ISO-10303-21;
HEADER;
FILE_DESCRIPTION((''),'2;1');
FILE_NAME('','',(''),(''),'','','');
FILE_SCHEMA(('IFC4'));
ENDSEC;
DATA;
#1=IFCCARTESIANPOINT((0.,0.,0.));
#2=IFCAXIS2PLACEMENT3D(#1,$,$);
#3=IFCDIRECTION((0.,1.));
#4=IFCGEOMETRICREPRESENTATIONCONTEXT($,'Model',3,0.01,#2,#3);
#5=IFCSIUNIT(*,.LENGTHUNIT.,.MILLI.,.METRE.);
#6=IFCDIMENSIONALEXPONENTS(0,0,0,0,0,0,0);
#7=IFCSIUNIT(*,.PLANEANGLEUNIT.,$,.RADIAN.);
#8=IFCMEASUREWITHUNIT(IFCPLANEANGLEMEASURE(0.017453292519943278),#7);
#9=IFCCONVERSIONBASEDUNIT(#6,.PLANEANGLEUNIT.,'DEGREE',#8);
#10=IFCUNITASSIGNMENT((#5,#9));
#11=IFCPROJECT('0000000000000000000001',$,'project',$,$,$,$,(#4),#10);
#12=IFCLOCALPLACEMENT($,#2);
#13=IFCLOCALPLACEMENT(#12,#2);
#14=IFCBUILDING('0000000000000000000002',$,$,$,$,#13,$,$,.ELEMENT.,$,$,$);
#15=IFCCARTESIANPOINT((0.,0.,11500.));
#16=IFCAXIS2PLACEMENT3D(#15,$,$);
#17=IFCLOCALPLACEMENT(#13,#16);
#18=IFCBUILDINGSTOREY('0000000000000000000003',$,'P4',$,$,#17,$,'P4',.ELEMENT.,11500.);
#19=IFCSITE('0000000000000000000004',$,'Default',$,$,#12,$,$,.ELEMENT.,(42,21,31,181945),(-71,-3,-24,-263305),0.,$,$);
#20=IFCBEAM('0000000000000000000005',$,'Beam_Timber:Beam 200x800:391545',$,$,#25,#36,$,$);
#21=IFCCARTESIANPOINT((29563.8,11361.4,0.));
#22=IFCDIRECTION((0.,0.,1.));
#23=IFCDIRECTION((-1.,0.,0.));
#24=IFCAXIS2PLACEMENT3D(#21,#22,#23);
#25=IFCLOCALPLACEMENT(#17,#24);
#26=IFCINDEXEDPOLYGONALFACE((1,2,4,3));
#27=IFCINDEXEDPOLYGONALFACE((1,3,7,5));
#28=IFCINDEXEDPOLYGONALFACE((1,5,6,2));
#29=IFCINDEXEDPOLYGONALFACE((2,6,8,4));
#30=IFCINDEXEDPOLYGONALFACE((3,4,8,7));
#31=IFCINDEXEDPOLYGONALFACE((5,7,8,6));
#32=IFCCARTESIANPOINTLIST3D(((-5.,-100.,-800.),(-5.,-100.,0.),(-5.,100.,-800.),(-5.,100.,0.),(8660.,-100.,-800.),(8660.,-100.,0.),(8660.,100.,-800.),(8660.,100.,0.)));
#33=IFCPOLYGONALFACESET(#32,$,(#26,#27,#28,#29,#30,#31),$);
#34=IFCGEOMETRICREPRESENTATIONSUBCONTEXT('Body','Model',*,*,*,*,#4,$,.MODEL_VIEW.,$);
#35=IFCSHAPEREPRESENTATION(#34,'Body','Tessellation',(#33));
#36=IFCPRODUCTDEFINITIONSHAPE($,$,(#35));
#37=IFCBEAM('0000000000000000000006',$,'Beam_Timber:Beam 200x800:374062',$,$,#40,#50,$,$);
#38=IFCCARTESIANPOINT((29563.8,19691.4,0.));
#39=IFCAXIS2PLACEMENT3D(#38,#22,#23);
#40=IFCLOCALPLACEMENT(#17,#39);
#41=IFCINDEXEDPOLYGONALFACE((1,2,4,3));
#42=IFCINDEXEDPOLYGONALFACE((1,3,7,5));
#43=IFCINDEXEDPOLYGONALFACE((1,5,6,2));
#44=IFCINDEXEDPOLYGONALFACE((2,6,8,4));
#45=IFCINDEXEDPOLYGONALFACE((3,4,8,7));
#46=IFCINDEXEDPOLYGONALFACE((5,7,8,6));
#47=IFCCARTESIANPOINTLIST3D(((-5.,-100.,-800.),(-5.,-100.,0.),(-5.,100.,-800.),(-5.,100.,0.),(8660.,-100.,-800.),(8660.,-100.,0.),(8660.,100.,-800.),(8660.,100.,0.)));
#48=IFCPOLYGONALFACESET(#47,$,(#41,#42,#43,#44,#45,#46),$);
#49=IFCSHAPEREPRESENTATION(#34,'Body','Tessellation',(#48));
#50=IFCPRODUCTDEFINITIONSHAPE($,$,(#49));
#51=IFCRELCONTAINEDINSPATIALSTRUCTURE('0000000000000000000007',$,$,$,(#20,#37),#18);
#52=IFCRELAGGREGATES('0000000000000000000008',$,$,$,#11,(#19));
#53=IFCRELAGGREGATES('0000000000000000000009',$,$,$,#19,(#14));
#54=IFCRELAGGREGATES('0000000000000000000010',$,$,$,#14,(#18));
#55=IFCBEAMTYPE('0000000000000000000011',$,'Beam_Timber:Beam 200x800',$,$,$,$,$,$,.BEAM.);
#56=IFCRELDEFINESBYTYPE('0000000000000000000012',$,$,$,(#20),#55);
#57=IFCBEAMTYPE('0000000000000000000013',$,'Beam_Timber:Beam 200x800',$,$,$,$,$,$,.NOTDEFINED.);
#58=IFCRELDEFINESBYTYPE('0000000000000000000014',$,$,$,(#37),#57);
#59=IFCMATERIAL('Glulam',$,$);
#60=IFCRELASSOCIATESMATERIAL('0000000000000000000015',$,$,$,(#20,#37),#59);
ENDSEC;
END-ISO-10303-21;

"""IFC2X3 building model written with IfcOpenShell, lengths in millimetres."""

from ifc_helpers import new_model, entity, si_unit, converted_unit, direction, frame, frame_2d, origin, origin_2d_with_axis, place, context, subcontext, project, spatial, rectangle, extrude, material, type_object, element, save


model = new_model("IFC2X3")

# Units and contexts
model_context = context("Model", 3, precision=0.01, world=origin(), true_north=direction((0.0, 1.0)))
body_context = subcontext(model_context, "Body", "Model", "MODEL_VIEW")
ifc_project = project(units=[si_unit("LENGTHUNIT", "METRE", prefix="MILLI"), converted_unit("PLANEANGLEUNIT", "DEGREE", entity("IfcPlaneAngleMeasure", 0.017453292519943278), si_unit("PLANEANGLEUNIT", "RADIAN"), dimensions=[0, 0, 0, 0, 0, 0, 0])], contexts=[model_context])

# Site, building, storey
site_placement = place(None, origin())
site = spatial("IfcSite", under=ifc_project, at=site_placement, Name="Default", CompositionType="ELEMENT", RefLatitude=(42, 21, 31, 181945), RefLongitude=(-71, -3, -24, -263305), RefElevation=0.0)
building_placement = place(site_placement, origin())
building = spatial("IfcBuilding", under=site, at=building_placement, CompositionType="ELEMENT")
storey_placement = place(building_placement, frame((0.0, 0.0, 11500.0)))
storey = spatial("IfcBuildingStorey", under=building, at=storey_placement, Name="P4", LongName="P4", CompositionType="ELEMENT", Elevation=11500.0)

# Shared definitions
ifc_material = material(Name="Glulam")

# Beams
beam_type_1 = type_object("IfcBeamType", Name="Beam_Timber:Beam 200x800", PredefinedType="BEAM")
beam_1_placement = place(storey_placement, frame((29563.8, 11361.4, 0.0), z_axis=(0.0, 0.0, 1.0), x_axis=(-1.0, 0.0, 0.0)))
element("IfcBeam", 1, at=beam_1_placement, inside=storey, type_object=beam_type_1, material=ifc_material, Name="Beam_Timber:Beam 200x800:391545", context=body_context, shape_type="SweptSolid", body=[
    extrude(rectangle(XDim=800.0, YDim=200.0, at=frame_2d((0.0, 0.0), x_axis=(1.0, 0.0))), frame((-5.0, 0.0, -400.0), z_axis=(1.0, 0.0, 0.0), x_axis=(0.0, 0.0, -1.0)), (0.0, 0.0, 1.0), 8665.0),
])
beam_type_2 = type_object("IfcBeamType", Name="Beam_Timber:Beam 200x800", PredefinedType="NOTDEFINED")
beam_2_placement = place(storey_placement, frame((29563.8, 19691.4, 0.0), z_axis=(0.0, 0.0, 1.0), x_axis=(-1.0, 0.0, 0.0)))
element("IfcBeam", 2, at=beam_2_placement, inside=storey, type_object=beam_type_2, material=ifc_material, Name="Beam_Timber:Beam 200x800:374062", context=body_context, shape_type="SweptSolid", body=[
    extrude(rectangle(XDim=800.0, YDim=200.0, at=origin_2d_with_axis()), frame((-5.0, 0.0, -400.0), z_axis=(1.0, 0.0, 0.0), x_axis=(0.0, 0.0, -1.0)), (0.0, 0.0, 1.0), 8665.0),
])

save(model, "model.ifc")
